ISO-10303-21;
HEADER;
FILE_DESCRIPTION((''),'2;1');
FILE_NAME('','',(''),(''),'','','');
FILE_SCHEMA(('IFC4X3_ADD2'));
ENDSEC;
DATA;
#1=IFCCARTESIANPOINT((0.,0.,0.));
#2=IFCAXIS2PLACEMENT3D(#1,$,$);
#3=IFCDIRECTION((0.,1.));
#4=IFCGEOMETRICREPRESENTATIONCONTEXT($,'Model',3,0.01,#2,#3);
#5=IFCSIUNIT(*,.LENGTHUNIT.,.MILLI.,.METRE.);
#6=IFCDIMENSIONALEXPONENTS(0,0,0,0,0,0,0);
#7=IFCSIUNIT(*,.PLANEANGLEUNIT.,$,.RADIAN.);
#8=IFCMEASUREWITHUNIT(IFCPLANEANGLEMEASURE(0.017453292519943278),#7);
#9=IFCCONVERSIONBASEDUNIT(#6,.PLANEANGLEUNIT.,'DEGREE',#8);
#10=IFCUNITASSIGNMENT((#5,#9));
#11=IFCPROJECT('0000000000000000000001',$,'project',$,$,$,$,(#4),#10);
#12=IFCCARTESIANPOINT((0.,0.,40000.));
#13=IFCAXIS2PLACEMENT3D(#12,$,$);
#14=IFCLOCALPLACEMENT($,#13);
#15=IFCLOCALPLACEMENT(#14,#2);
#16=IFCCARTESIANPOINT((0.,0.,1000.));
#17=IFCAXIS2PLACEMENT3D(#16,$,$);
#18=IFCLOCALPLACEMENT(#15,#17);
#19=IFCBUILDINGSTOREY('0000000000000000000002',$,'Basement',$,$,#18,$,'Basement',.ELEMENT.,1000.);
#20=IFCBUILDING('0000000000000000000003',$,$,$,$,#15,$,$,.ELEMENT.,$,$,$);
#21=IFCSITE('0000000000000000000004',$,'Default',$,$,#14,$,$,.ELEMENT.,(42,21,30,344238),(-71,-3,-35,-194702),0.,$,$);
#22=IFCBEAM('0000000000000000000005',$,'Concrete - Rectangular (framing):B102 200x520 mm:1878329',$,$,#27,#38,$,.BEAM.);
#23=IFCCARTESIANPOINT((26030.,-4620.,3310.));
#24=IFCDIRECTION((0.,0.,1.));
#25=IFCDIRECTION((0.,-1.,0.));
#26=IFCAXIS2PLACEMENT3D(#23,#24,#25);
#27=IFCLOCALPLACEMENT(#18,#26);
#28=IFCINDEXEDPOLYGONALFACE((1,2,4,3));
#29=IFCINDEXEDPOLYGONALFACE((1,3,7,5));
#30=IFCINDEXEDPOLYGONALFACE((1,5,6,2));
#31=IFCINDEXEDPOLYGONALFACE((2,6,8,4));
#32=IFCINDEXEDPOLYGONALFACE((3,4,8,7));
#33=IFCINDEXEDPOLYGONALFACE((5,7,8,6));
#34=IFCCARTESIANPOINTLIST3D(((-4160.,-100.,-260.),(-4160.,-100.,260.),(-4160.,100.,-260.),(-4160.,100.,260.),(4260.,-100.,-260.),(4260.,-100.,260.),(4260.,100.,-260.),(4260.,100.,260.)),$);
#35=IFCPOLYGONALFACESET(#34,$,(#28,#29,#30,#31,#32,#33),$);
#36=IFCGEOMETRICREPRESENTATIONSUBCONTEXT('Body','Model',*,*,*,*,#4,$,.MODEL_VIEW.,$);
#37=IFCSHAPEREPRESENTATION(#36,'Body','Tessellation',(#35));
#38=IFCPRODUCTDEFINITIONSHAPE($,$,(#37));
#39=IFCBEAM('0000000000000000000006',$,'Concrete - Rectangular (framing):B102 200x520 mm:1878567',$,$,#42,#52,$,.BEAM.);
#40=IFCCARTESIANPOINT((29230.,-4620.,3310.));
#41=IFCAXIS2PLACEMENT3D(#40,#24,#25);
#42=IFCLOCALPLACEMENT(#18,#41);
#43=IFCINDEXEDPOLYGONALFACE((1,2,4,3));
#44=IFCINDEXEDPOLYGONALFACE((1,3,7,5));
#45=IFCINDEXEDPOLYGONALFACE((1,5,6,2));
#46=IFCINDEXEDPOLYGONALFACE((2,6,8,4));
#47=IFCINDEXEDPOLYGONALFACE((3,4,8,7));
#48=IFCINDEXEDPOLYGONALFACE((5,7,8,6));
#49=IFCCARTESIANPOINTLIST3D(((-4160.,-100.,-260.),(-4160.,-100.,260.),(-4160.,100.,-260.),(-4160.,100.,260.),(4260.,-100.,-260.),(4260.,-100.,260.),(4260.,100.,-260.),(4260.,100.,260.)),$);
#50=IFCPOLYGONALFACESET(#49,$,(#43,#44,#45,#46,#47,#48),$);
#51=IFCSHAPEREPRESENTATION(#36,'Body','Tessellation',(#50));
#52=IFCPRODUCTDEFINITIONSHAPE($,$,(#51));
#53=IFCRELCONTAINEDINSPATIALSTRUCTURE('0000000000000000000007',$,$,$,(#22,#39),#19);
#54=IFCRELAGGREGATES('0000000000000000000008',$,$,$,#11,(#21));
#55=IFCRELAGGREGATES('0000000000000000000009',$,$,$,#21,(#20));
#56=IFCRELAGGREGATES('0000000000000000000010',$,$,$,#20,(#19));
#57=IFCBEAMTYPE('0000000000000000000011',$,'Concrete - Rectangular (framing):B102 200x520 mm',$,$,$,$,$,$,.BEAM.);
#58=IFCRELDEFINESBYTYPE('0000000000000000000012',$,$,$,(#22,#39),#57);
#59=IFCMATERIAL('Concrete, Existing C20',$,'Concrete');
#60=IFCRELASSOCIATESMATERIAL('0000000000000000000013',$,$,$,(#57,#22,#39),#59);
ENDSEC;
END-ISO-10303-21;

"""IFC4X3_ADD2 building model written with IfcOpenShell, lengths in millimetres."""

from ifc_helpers import new_model, entity, si_unit, converted_unit, direction, frame, origin, origin_2d_with_axis, place, context, subcontext, project, spatial, rectangle, extrude, source, transform, mapped, material, material_profile, profile_set, profile_usage, type_object, type_shapes, element, save


model = new_model("IFC4X3_ADD2")

# Units and contexts
model_context = context("Model", 3, precision=0.01, world=origin(), true_north=direction((0.0, 1.0)))
body_context = subcontext(model_context, "Body", "Model", "MODEL_VIEW")
ifc_project = project(units=[si_unit("LENGTHUNIT", "METRE", prefix="MILLI"), converted_unit("PLANEANGLEUNIT", "DEGREE", entity("IfcPlaneAngleMeasure", 0.017453292519943278), si_unit("PLANEANGLEUNIT", "RADIAN"), dimensions=[0, 0, 0, 0, 0, 0, 0])], contexts=[model_context])

# Site, building, storey
site_placement = place(None, frame((0.0, 0.0, 40000.0)))
site = spatial("IfcSite", under=ifc_project, at=site_placement, Name="Default", CompositionType="ELEMENT", RefLatitude=(42, 21, 30, 344238), RefLongitude=(-71, -3, -35, -194702), RefElevation=0.0)
building_placement = place(site_placement, origin())
building = spatial("IfcBuilding", under=site, at=building_placement, CompositionType="ELEMENT")
storey_placement = place(building_placement, frame((0.0, 0.0, 1000.0)))
storey = spatial("IfcBuildingStorey", under=building, at=storey_placement, Name="Basement", LongName="Basement", CompositionType="ELEMENT", Elevation=1000.0)

# Shared definitions
ifc_material_1 = material(Name="Concrete, Existing C20", Category="Concrete")

# Beams
ifc_material_profile_1 = material_profile(ifc_material_1, rectangle(XDim=8519.8, YDim=200.0, at=origin_2d_with_axis()), Name="B102 200x520 mm")
ifc_profile_set_1 = profile_set([ifc_material_profile_1], Name="B102 200x520 mm")
ifc_profile_usage_1 = profile_usage(ifc_profile_set_1, cardinal=8)
beam_type_1 = type_object("IfcBeamType", Name="Concrete - Rectangular (framing):B102 200x520 mm", PredefinedType="BEAM", material=ifc_profile_set_1)
shared_shape_1 = source(origin(), body_context, "Body", "SweptSolid", [
    extrude(rectangle(XDim=8420.0, YDim=200.0, at=origin_2d_with_axis()), frame((50.0, 0.0, -260.0), z_axis=(0.0, 0.0, 1.0), x_axis=(-1.0, 0.0, 0.0)), (0.0, 0.0, 1.0), 520.0),
])
type_shapes(beam_type_1, [shared_shape_1])
for number, where, z_axis, x_axis, name in (
    (1, (26030.0, -4620.0, 3310.0), (0.0, 0.0, 1.0), (0.0, -1.0, 0.0), "Concrete - Rectangular (framing):B102 200x520 mm:1878329"),
    (2, (29230.0, -4620.0, 3310.0), (0.0, 0.0, 1.0), (0.0, -1.0, 0.0), "Concrete - Rectangular (framing):B102 200x520 mm:1878567"),
):
    element("IfcBeam", number, at=place(storey_placement, frame(where, z_axis=z_axis, x_axis=x_axis)), inside=storey, type_object=beam_type_1, material=ifc_profile_usage_1, Name=name, PredefinedType="BEAM", context=body_context, shape_type="MappedRepresentation", body=[
        mapped(shared_shape_1, transform((0.0, 0.0, 0.0), scale=1.0)),
    ])

save(model, "model.ifc")
